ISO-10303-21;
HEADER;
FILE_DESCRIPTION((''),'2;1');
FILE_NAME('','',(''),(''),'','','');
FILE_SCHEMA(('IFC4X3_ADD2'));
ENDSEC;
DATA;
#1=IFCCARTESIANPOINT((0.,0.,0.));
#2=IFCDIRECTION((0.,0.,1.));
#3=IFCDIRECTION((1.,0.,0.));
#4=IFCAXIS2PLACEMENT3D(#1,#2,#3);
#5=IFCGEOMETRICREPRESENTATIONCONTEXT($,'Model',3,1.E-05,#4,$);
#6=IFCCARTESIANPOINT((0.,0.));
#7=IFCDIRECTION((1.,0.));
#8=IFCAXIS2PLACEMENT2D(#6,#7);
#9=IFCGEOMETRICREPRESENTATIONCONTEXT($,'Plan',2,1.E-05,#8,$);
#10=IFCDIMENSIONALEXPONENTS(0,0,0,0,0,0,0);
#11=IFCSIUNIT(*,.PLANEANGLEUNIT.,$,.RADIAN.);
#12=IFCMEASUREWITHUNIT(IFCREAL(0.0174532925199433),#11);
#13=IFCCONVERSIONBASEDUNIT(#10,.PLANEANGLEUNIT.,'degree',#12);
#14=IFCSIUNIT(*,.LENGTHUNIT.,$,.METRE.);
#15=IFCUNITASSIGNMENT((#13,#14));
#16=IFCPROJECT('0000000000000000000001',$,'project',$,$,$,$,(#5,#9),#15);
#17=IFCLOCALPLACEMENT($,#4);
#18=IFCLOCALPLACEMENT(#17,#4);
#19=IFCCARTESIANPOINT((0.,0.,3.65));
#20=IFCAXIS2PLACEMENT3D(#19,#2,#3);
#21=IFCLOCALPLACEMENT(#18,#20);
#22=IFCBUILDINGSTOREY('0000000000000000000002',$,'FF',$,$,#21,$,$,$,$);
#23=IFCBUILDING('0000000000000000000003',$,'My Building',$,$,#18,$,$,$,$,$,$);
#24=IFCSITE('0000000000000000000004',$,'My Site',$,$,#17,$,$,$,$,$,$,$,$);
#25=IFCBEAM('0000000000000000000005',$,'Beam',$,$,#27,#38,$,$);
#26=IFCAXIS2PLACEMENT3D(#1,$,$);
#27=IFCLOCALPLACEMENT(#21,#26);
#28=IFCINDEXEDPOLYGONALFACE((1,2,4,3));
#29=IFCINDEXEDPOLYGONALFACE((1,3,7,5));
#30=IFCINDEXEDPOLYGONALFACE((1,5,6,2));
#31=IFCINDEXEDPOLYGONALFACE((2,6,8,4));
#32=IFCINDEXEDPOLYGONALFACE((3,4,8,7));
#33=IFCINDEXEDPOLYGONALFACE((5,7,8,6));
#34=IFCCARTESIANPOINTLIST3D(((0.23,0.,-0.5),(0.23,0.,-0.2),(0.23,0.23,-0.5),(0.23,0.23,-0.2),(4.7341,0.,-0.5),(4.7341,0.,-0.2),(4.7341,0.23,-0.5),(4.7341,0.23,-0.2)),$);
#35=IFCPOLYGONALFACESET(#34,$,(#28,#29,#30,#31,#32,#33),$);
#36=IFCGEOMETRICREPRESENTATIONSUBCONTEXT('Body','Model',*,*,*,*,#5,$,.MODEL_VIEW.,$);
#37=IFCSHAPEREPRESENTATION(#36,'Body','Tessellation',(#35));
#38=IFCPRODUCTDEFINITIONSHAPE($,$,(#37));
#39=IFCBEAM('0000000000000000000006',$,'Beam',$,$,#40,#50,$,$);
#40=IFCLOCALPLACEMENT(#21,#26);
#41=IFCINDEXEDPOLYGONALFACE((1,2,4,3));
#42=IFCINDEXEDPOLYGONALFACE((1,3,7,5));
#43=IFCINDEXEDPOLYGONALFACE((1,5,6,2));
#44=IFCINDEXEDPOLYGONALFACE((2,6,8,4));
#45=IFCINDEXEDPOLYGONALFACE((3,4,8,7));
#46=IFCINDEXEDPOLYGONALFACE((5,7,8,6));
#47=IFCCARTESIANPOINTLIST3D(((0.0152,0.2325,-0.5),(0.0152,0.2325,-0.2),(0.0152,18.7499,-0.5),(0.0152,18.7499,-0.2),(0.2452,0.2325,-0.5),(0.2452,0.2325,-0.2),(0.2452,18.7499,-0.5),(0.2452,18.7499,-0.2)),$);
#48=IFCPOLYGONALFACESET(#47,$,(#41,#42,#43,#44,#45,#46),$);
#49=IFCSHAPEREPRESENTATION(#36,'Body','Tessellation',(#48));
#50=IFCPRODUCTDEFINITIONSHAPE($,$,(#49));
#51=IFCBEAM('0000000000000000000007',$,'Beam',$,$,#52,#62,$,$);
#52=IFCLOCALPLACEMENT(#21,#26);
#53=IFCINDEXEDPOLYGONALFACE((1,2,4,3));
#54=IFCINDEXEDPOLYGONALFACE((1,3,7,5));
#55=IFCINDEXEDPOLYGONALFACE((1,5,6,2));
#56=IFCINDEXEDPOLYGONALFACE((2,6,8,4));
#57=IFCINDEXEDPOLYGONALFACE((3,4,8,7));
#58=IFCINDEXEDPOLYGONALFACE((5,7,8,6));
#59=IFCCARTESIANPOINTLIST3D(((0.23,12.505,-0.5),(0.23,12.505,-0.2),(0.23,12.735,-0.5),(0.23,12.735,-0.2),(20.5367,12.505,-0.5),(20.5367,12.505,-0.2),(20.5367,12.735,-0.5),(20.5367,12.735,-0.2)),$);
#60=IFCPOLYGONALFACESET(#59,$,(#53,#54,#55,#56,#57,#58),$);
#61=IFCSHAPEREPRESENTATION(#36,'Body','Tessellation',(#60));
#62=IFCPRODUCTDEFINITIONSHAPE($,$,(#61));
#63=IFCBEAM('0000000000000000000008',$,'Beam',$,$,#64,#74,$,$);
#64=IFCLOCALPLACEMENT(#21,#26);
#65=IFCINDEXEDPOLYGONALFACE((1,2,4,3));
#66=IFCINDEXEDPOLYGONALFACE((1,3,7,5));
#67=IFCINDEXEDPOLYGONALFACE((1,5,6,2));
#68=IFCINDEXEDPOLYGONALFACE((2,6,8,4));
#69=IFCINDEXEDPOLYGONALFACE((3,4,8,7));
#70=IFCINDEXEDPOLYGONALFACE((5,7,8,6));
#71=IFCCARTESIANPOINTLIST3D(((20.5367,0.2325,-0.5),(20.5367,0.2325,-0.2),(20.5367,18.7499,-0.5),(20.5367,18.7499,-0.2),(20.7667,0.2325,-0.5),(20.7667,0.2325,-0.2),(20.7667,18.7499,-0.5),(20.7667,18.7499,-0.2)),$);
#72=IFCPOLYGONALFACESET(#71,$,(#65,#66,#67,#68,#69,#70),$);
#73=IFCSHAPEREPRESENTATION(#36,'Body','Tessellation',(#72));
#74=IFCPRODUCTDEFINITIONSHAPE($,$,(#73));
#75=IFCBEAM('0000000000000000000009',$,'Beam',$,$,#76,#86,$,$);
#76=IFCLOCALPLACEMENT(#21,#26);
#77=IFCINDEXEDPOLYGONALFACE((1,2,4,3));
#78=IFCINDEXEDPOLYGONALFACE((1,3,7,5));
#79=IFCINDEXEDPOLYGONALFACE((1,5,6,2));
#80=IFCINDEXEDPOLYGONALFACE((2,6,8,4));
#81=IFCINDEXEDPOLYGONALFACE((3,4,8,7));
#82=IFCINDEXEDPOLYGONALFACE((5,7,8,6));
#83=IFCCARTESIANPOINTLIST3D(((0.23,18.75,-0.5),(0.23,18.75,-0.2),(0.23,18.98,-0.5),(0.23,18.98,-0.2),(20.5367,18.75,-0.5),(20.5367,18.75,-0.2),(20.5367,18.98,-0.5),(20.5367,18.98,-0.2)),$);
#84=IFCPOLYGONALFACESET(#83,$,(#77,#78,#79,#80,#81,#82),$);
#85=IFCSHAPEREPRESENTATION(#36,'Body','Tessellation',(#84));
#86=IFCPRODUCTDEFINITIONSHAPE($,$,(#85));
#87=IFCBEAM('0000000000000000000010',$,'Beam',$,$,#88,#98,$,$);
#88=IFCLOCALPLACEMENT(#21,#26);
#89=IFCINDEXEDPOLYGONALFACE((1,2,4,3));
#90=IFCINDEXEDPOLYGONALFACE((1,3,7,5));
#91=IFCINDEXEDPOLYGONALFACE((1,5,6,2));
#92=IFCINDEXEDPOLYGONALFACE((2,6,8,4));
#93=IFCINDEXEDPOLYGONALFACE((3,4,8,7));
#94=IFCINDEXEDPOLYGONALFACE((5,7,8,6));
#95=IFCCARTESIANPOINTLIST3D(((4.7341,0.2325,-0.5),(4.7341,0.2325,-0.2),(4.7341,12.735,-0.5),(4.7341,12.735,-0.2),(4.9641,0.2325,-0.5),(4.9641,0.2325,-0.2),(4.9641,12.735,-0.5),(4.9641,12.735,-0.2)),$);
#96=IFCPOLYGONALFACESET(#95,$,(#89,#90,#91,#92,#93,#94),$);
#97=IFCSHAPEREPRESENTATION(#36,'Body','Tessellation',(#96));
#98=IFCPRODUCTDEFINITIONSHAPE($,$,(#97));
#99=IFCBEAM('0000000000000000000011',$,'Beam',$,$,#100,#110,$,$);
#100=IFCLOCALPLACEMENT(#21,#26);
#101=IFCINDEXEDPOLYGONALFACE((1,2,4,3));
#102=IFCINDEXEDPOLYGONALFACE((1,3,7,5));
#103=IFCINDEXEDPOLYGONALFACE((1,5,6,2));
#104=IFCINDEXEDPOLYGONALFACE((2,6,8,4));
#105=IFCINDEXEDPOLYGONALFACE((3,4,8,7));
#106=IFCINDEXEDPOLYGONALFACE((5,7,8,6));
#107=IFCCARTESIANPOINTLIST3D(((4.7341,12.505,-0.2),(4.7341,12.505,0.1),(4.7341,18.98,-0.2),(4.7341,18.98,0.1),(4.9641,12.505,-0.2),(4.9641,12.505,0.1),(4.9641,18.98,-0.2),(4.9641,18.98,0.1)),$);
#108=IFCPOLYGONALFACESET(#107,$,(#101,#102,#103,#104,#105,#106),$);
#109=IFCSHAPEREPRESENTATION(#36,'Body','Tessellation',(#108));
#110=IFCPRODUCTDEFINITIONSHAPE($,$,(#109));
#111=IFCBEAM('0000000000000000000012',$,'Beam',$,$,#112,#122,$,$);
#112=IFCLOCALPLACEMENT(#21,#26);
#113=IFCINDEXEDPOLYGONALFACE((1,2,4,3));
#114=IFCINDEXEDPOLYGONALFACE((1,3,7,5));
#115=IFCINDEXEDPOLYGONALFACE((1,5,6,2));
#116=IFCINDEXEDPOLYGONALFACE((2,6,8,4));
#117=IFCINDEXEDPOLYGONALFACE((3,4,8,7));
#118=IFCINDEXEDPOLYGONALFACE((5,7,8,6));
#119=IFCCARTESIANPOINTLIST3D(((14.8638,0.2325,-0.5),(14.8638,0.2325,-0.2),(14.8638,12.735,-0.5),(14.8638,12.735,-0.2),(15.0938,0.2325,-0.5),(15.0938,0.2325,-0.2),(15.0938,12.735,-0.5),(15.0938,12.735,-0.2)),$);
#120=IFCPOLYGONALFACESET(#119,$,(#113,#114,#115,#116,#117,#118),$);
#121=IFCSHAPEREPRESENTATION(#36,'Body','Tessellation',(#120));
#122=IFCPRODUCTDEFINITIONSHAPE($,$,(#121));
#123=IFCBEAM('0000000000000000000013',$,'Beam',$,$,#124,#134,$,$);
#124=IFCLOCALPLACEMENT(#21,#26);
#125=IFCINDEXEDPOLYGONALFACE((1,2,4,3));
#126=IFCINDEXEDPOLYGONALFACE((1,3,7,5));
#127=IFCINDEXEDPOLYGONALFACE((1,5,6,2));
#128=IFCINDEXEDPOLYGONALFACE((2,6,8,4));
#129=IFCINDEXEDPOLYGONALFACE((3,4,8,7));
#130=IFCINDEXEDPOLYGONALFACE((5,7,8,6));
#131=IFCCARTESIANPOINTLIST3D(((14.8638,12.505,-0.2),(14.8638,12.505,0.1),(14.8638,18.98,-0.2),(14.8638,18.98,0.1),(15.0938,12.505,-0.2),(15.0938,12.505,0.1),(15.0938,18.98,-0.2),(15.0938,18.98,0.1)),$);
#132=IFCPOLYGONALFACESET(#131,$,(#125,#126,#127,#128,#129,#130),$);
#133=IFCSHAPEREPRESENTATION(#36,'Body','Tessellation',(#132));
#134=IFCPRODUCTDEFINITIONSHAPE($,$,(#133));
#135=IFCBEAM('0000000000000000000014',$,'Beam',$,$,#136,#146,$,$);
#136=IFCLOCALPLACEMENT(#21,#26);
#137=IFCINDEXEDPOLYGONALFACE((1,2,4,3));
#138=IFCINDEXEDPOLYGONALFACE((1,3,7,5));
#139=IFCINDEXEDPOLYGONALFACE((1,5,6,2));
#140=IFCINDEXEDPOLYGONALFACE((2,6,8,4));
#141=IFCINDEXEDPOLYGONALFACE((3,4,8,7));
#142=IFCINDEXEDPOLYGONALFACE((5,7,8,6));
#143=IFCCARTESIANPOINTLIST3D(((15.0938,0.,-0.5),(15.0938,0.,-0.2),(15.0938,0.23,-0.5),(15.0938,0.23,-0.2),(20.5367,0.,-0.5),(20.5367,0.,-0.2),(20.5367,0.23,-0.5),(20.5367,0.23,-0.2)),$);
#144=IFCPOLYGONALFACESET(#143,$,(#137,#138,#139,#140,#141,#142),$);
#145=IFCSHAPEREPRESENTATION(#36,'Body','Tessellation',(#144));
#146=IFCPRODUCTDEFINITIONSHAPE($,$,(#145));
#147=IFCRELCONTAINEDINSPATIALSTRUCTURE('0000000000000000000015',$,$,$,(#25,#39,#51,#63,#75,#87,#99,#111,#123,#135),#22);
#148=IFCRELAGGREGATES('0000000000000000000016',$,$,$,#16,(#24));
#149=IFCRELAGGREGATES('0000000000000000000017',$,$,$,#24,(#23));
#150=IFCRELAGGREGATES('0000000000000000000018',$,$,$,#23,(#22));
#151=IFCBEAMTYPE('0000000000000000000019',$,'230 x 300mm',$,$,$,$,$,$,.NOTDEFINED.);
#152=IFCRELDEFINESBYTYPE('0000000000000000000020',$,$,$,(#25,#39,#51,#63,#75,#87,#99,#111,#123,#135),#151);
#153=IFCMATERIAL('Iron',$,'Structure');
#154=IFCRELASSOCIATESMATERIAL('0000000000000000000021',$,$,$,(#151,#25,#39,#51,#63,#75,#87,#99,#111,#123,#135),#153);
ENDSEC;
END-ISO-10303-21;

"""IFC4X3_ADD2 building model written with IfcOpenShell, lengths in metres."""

from ifc_helpers import new_model, entity, si_unit, converted_unit, frame, origin_with_axes, origin_2d_with_axis, place, context, subcontext, project, spatial, rectangle, extrude, material, material_profile, profile_set, profile_usage, type_object, element, save


model = new_model("IFC4X3_ADD2")

# Units and contexts
model_context = context("Model", 3, precision=1e-05, world=origin_with_axes())
plan_context = context("Plan", 2, precision=1e-05, world=origin_2d_with_axis())
body_context = subcontext(model_context, "Body", "Model", "MODEL_VIEW")
ifc_project = project(units=[converted_unit("PLANEANGLEUNIT", "degree", entity("IfcReal", 0.0174532925199433), si_unit("PLANEANGLEUNIT", "RADIAN"), dimensions=[0, 0, 0, 0, 0, 0, 0]), si_unit("LENGTHUNIT", "METRE")], contexts=[model_context, plan_context])

# Site, building, storey
site_placement = place(None, origin_with_axes())
site = spatial("IfcSite", under=ifc_project, at=site_placement, Name="My Site")
building_placement = place(site_placement, origin_with_axes())
building = spatial("IfcBuilding", under=site, at=building_placement, Name="My Building")
storey_placement = place(building_placement, frame((0.0, 0.0, 3.65), z_axis=(0.0, 0.0, 1.0), x_axis=(1.0, 0.0, 0.0)))
storey = spatial("IfcBuildingStorey", under=building, at=storey_placement, Name="FF")

# Beams
ifc_material = material(Name="Iron", Category="Structure")
ifc_material_profile = material_profile(ifc_material, rectangle(XDim=0.23, YDim=0.3))
ifc_profile_set = profile_set([ifc_material_profile])
ifc_profile_usage_1 = profile_usage(ifc_profile_set)
beam_type = type_object("IfcBeamType", Name="230 x 300mm", PredefinedType="NOTDEFINED", material=ifc_profile_set)
beam_1_placement = place(storey_placement, frame((0.23, 0.115, -0.35), z_axis=(1.0, 0.0, 0.0), x_axis=(0.0, 1.0, 0.0)))
element("IfcBeam", 1, at=beam_1_placement, inside=storey, type_object=beam_type, material=ifc_profile_usage_1, Name="Beam", context=body_context, shape_type="SweptSolid", body=[
    extrude(rectangle(XDim=0.23, YDim=0.3), origin_with_axes(), (0.0, 0.0, 1.0), 4.5041),
])
ifc_profile_usage_2 = profile_usage(ifc_profile_set)
beam_2_placement = place(storey_placement, frame((0.1302, 18.7499, -0.35), z_axis=(0.0, -1.0, 0.0), x_axis=(1.0, 0.0, 0.0)))
element("IfcBeam", 2, at=beam_2_placement, inside=storey, type_object=beam_type, material=ifc_profile_usage_2, Name="Beam", context=body_context, shape_type="SweptSolid", body=[
    extrude(rectangle(XDim=0.23, YDim=0.3), origin_with_axes(), (0.0, 0.0, 1.0), 18.5174),
])
ifc_profile_usage_3 = profile_usage(ifc_profile_set)
beam_3_placement = place(storey_placement, frame((0.23, 12.62, -0.35), z_axis=(1.0, -0.000001, 0.0), x_axis=(0.000001, 1.0, 0.0)))
element("IfcBeam", 3, at=beam_3_placement, inside=storey, type_object=beam_type, material=ifc_profile_usage_3, Name="Beam", context=body_context, shape_type="SweptSolid", body=[
    extrude(rectangle(XDim=0.23, YDim=0.3), origin_with_axes(), (0.0, 0.0, 1.0), 20.3067),
])
ifc_profile_usage_4 = profile_usage(ifc_profile_set)
beam_4_placement = place(storey_placement, frame((20.6517, 18.7499, -0.35), z_axis=(0.0, -1.0, 0.0), x_axis=(1.0, 0.0, 0.0)))
element("IfcBeam", 4, at=beam_4_placement, inside=storey, type_object=beam_type, material=ifc_profile_usage_4, Name="Beam", context=body_context, shape_type="SweptSolid", body=[
    extrude(rectangle(XDim=0.23, YDim=0.3), origin_with_axes(), (0.0, 0.0, 1.0), 18.5174),
])
ifc_profile_usage_5 = profile_usage(ifc_profile_set)
beam_5_placement = place(storey_placement, frame((0.23, 18.865, -0.35), z_axis=(1.0, 0.0, 0.0), x_axis=(0.0, 1.0, 0.0)))
element("IfcBeam", 5, at=beam_5_placement, inside=storey, type_object=beam_type, material=ifc_profile_usage_5, Name="Beam", context=body_context, shape_type="SweptSolid", body=[
    extrude(rectangle(XDim=0.23, YDim=0.3), origin_with_axes(), (0.0, 0.0, 1.0), 20.3067),
])
ifc_profile_usage_6 = profile_usage(ifc_profile_set)
beam_6_placement = place(storey_placement, frame((4.8491, 12.735, -0.35), z_axis=(0.0, -1.0, 0.0), x_axis=(1.0, 0.0, 0.0)))
element("IfcBeam", 6, at=beam_6_placement, inside=storey, type_object=beam_type, material=ifc_profile_usage_6, Name="Beam", context=body_context, shape_type="SweptSolid", body=[
    extrude(rectangle(XDim=0.23, YDim=0.3), origin_with_axes(), (0.0, 0.0, 1.0), 12.5025),
])
ifc_profile_usage_7 = profile_usage(ifc_profile_set)
beam_7_placement = place(storey_placement, frame((4.8491, 18.98, -0.05), z_axis=(0.0, -1.0, 0.0), x_axis=(1.0, 0.0, 0.0)))
element("IfcBeam", 7, at=beam_7_placement, inside=storey, type_object=beam_type, material=ifc_profile_usage_7, Name="Beam", context=body_context, shape_type="SweptSolid", body=[
    extrude(rectangle(XDim=0.23, YDim=0.3), origin_with_axes(), (0.0, 0.0, 1.0), 6.475),
])
ifc_profile_usage_8 = profile_usage(ifc_profile_set)
beam_8_placement = place(storey_placement, frame((14.9788, 12.735, -0.35), z_axis=(0.0, -1.0, 0.0), x_axis=(1.0, 0.0, 0.0)))
element("IfcBeam", 8, at=beam_8_placement, inside=storey, type_object=beam_type, material=ifc_profile_usage_8, Name="Beam", context=body_context, shape_type="SweptSolid", body=[
    extrude(rectangle(XDim=0.23, YDim=0.3), origin_with_axes(), (0.0, 0.0, 1.0), 12.5025),
])
ifc_profile_usage_9 = profile_usage(ifc_profile_set)
beam_9_placement = place(storey_placement, frame((14.9788, 18.98, -0.05), z_axis=(0.0, -1.0, 0.0), x_axis=(1.0, 0.0, 0.0)))
element("IfcBeam", 9, at=beam_9_placement, inside=storey, type_object=beam_type, material=ifc_profile_usage_9, Name="Beam", context=body_context, shape_type="SweptSolid", body=[
    extrude(rectangle(XDim=0.23, YDim=0.3), origin_with_axes(), (0.0, 0.0, 1.0), 6.475),
])
ifc_profile_usage_10 = profile_usage(ifc_profile_set)
beam_10_placement = place(storey_placement, frame((15.0938, 0.115, -0.35), z_axis=(1.0, 0.0, 0.0), x_axis=(0.0, 1.0, 0.0)))
element("IfcBeam", 10, at=beam_10_placement, inside=storey, type_object=beam_type, material=ifc_profile_usage_10, Name="Beam", context=body_context, shape_type="SweptSolid", body=[
    extrude(rectangle(XDim=0.23, YDim=0.3), origin_with_axes(), (0.0, 0.0, 1.0), 5.4429),
])

save(model, "model.ifc")
